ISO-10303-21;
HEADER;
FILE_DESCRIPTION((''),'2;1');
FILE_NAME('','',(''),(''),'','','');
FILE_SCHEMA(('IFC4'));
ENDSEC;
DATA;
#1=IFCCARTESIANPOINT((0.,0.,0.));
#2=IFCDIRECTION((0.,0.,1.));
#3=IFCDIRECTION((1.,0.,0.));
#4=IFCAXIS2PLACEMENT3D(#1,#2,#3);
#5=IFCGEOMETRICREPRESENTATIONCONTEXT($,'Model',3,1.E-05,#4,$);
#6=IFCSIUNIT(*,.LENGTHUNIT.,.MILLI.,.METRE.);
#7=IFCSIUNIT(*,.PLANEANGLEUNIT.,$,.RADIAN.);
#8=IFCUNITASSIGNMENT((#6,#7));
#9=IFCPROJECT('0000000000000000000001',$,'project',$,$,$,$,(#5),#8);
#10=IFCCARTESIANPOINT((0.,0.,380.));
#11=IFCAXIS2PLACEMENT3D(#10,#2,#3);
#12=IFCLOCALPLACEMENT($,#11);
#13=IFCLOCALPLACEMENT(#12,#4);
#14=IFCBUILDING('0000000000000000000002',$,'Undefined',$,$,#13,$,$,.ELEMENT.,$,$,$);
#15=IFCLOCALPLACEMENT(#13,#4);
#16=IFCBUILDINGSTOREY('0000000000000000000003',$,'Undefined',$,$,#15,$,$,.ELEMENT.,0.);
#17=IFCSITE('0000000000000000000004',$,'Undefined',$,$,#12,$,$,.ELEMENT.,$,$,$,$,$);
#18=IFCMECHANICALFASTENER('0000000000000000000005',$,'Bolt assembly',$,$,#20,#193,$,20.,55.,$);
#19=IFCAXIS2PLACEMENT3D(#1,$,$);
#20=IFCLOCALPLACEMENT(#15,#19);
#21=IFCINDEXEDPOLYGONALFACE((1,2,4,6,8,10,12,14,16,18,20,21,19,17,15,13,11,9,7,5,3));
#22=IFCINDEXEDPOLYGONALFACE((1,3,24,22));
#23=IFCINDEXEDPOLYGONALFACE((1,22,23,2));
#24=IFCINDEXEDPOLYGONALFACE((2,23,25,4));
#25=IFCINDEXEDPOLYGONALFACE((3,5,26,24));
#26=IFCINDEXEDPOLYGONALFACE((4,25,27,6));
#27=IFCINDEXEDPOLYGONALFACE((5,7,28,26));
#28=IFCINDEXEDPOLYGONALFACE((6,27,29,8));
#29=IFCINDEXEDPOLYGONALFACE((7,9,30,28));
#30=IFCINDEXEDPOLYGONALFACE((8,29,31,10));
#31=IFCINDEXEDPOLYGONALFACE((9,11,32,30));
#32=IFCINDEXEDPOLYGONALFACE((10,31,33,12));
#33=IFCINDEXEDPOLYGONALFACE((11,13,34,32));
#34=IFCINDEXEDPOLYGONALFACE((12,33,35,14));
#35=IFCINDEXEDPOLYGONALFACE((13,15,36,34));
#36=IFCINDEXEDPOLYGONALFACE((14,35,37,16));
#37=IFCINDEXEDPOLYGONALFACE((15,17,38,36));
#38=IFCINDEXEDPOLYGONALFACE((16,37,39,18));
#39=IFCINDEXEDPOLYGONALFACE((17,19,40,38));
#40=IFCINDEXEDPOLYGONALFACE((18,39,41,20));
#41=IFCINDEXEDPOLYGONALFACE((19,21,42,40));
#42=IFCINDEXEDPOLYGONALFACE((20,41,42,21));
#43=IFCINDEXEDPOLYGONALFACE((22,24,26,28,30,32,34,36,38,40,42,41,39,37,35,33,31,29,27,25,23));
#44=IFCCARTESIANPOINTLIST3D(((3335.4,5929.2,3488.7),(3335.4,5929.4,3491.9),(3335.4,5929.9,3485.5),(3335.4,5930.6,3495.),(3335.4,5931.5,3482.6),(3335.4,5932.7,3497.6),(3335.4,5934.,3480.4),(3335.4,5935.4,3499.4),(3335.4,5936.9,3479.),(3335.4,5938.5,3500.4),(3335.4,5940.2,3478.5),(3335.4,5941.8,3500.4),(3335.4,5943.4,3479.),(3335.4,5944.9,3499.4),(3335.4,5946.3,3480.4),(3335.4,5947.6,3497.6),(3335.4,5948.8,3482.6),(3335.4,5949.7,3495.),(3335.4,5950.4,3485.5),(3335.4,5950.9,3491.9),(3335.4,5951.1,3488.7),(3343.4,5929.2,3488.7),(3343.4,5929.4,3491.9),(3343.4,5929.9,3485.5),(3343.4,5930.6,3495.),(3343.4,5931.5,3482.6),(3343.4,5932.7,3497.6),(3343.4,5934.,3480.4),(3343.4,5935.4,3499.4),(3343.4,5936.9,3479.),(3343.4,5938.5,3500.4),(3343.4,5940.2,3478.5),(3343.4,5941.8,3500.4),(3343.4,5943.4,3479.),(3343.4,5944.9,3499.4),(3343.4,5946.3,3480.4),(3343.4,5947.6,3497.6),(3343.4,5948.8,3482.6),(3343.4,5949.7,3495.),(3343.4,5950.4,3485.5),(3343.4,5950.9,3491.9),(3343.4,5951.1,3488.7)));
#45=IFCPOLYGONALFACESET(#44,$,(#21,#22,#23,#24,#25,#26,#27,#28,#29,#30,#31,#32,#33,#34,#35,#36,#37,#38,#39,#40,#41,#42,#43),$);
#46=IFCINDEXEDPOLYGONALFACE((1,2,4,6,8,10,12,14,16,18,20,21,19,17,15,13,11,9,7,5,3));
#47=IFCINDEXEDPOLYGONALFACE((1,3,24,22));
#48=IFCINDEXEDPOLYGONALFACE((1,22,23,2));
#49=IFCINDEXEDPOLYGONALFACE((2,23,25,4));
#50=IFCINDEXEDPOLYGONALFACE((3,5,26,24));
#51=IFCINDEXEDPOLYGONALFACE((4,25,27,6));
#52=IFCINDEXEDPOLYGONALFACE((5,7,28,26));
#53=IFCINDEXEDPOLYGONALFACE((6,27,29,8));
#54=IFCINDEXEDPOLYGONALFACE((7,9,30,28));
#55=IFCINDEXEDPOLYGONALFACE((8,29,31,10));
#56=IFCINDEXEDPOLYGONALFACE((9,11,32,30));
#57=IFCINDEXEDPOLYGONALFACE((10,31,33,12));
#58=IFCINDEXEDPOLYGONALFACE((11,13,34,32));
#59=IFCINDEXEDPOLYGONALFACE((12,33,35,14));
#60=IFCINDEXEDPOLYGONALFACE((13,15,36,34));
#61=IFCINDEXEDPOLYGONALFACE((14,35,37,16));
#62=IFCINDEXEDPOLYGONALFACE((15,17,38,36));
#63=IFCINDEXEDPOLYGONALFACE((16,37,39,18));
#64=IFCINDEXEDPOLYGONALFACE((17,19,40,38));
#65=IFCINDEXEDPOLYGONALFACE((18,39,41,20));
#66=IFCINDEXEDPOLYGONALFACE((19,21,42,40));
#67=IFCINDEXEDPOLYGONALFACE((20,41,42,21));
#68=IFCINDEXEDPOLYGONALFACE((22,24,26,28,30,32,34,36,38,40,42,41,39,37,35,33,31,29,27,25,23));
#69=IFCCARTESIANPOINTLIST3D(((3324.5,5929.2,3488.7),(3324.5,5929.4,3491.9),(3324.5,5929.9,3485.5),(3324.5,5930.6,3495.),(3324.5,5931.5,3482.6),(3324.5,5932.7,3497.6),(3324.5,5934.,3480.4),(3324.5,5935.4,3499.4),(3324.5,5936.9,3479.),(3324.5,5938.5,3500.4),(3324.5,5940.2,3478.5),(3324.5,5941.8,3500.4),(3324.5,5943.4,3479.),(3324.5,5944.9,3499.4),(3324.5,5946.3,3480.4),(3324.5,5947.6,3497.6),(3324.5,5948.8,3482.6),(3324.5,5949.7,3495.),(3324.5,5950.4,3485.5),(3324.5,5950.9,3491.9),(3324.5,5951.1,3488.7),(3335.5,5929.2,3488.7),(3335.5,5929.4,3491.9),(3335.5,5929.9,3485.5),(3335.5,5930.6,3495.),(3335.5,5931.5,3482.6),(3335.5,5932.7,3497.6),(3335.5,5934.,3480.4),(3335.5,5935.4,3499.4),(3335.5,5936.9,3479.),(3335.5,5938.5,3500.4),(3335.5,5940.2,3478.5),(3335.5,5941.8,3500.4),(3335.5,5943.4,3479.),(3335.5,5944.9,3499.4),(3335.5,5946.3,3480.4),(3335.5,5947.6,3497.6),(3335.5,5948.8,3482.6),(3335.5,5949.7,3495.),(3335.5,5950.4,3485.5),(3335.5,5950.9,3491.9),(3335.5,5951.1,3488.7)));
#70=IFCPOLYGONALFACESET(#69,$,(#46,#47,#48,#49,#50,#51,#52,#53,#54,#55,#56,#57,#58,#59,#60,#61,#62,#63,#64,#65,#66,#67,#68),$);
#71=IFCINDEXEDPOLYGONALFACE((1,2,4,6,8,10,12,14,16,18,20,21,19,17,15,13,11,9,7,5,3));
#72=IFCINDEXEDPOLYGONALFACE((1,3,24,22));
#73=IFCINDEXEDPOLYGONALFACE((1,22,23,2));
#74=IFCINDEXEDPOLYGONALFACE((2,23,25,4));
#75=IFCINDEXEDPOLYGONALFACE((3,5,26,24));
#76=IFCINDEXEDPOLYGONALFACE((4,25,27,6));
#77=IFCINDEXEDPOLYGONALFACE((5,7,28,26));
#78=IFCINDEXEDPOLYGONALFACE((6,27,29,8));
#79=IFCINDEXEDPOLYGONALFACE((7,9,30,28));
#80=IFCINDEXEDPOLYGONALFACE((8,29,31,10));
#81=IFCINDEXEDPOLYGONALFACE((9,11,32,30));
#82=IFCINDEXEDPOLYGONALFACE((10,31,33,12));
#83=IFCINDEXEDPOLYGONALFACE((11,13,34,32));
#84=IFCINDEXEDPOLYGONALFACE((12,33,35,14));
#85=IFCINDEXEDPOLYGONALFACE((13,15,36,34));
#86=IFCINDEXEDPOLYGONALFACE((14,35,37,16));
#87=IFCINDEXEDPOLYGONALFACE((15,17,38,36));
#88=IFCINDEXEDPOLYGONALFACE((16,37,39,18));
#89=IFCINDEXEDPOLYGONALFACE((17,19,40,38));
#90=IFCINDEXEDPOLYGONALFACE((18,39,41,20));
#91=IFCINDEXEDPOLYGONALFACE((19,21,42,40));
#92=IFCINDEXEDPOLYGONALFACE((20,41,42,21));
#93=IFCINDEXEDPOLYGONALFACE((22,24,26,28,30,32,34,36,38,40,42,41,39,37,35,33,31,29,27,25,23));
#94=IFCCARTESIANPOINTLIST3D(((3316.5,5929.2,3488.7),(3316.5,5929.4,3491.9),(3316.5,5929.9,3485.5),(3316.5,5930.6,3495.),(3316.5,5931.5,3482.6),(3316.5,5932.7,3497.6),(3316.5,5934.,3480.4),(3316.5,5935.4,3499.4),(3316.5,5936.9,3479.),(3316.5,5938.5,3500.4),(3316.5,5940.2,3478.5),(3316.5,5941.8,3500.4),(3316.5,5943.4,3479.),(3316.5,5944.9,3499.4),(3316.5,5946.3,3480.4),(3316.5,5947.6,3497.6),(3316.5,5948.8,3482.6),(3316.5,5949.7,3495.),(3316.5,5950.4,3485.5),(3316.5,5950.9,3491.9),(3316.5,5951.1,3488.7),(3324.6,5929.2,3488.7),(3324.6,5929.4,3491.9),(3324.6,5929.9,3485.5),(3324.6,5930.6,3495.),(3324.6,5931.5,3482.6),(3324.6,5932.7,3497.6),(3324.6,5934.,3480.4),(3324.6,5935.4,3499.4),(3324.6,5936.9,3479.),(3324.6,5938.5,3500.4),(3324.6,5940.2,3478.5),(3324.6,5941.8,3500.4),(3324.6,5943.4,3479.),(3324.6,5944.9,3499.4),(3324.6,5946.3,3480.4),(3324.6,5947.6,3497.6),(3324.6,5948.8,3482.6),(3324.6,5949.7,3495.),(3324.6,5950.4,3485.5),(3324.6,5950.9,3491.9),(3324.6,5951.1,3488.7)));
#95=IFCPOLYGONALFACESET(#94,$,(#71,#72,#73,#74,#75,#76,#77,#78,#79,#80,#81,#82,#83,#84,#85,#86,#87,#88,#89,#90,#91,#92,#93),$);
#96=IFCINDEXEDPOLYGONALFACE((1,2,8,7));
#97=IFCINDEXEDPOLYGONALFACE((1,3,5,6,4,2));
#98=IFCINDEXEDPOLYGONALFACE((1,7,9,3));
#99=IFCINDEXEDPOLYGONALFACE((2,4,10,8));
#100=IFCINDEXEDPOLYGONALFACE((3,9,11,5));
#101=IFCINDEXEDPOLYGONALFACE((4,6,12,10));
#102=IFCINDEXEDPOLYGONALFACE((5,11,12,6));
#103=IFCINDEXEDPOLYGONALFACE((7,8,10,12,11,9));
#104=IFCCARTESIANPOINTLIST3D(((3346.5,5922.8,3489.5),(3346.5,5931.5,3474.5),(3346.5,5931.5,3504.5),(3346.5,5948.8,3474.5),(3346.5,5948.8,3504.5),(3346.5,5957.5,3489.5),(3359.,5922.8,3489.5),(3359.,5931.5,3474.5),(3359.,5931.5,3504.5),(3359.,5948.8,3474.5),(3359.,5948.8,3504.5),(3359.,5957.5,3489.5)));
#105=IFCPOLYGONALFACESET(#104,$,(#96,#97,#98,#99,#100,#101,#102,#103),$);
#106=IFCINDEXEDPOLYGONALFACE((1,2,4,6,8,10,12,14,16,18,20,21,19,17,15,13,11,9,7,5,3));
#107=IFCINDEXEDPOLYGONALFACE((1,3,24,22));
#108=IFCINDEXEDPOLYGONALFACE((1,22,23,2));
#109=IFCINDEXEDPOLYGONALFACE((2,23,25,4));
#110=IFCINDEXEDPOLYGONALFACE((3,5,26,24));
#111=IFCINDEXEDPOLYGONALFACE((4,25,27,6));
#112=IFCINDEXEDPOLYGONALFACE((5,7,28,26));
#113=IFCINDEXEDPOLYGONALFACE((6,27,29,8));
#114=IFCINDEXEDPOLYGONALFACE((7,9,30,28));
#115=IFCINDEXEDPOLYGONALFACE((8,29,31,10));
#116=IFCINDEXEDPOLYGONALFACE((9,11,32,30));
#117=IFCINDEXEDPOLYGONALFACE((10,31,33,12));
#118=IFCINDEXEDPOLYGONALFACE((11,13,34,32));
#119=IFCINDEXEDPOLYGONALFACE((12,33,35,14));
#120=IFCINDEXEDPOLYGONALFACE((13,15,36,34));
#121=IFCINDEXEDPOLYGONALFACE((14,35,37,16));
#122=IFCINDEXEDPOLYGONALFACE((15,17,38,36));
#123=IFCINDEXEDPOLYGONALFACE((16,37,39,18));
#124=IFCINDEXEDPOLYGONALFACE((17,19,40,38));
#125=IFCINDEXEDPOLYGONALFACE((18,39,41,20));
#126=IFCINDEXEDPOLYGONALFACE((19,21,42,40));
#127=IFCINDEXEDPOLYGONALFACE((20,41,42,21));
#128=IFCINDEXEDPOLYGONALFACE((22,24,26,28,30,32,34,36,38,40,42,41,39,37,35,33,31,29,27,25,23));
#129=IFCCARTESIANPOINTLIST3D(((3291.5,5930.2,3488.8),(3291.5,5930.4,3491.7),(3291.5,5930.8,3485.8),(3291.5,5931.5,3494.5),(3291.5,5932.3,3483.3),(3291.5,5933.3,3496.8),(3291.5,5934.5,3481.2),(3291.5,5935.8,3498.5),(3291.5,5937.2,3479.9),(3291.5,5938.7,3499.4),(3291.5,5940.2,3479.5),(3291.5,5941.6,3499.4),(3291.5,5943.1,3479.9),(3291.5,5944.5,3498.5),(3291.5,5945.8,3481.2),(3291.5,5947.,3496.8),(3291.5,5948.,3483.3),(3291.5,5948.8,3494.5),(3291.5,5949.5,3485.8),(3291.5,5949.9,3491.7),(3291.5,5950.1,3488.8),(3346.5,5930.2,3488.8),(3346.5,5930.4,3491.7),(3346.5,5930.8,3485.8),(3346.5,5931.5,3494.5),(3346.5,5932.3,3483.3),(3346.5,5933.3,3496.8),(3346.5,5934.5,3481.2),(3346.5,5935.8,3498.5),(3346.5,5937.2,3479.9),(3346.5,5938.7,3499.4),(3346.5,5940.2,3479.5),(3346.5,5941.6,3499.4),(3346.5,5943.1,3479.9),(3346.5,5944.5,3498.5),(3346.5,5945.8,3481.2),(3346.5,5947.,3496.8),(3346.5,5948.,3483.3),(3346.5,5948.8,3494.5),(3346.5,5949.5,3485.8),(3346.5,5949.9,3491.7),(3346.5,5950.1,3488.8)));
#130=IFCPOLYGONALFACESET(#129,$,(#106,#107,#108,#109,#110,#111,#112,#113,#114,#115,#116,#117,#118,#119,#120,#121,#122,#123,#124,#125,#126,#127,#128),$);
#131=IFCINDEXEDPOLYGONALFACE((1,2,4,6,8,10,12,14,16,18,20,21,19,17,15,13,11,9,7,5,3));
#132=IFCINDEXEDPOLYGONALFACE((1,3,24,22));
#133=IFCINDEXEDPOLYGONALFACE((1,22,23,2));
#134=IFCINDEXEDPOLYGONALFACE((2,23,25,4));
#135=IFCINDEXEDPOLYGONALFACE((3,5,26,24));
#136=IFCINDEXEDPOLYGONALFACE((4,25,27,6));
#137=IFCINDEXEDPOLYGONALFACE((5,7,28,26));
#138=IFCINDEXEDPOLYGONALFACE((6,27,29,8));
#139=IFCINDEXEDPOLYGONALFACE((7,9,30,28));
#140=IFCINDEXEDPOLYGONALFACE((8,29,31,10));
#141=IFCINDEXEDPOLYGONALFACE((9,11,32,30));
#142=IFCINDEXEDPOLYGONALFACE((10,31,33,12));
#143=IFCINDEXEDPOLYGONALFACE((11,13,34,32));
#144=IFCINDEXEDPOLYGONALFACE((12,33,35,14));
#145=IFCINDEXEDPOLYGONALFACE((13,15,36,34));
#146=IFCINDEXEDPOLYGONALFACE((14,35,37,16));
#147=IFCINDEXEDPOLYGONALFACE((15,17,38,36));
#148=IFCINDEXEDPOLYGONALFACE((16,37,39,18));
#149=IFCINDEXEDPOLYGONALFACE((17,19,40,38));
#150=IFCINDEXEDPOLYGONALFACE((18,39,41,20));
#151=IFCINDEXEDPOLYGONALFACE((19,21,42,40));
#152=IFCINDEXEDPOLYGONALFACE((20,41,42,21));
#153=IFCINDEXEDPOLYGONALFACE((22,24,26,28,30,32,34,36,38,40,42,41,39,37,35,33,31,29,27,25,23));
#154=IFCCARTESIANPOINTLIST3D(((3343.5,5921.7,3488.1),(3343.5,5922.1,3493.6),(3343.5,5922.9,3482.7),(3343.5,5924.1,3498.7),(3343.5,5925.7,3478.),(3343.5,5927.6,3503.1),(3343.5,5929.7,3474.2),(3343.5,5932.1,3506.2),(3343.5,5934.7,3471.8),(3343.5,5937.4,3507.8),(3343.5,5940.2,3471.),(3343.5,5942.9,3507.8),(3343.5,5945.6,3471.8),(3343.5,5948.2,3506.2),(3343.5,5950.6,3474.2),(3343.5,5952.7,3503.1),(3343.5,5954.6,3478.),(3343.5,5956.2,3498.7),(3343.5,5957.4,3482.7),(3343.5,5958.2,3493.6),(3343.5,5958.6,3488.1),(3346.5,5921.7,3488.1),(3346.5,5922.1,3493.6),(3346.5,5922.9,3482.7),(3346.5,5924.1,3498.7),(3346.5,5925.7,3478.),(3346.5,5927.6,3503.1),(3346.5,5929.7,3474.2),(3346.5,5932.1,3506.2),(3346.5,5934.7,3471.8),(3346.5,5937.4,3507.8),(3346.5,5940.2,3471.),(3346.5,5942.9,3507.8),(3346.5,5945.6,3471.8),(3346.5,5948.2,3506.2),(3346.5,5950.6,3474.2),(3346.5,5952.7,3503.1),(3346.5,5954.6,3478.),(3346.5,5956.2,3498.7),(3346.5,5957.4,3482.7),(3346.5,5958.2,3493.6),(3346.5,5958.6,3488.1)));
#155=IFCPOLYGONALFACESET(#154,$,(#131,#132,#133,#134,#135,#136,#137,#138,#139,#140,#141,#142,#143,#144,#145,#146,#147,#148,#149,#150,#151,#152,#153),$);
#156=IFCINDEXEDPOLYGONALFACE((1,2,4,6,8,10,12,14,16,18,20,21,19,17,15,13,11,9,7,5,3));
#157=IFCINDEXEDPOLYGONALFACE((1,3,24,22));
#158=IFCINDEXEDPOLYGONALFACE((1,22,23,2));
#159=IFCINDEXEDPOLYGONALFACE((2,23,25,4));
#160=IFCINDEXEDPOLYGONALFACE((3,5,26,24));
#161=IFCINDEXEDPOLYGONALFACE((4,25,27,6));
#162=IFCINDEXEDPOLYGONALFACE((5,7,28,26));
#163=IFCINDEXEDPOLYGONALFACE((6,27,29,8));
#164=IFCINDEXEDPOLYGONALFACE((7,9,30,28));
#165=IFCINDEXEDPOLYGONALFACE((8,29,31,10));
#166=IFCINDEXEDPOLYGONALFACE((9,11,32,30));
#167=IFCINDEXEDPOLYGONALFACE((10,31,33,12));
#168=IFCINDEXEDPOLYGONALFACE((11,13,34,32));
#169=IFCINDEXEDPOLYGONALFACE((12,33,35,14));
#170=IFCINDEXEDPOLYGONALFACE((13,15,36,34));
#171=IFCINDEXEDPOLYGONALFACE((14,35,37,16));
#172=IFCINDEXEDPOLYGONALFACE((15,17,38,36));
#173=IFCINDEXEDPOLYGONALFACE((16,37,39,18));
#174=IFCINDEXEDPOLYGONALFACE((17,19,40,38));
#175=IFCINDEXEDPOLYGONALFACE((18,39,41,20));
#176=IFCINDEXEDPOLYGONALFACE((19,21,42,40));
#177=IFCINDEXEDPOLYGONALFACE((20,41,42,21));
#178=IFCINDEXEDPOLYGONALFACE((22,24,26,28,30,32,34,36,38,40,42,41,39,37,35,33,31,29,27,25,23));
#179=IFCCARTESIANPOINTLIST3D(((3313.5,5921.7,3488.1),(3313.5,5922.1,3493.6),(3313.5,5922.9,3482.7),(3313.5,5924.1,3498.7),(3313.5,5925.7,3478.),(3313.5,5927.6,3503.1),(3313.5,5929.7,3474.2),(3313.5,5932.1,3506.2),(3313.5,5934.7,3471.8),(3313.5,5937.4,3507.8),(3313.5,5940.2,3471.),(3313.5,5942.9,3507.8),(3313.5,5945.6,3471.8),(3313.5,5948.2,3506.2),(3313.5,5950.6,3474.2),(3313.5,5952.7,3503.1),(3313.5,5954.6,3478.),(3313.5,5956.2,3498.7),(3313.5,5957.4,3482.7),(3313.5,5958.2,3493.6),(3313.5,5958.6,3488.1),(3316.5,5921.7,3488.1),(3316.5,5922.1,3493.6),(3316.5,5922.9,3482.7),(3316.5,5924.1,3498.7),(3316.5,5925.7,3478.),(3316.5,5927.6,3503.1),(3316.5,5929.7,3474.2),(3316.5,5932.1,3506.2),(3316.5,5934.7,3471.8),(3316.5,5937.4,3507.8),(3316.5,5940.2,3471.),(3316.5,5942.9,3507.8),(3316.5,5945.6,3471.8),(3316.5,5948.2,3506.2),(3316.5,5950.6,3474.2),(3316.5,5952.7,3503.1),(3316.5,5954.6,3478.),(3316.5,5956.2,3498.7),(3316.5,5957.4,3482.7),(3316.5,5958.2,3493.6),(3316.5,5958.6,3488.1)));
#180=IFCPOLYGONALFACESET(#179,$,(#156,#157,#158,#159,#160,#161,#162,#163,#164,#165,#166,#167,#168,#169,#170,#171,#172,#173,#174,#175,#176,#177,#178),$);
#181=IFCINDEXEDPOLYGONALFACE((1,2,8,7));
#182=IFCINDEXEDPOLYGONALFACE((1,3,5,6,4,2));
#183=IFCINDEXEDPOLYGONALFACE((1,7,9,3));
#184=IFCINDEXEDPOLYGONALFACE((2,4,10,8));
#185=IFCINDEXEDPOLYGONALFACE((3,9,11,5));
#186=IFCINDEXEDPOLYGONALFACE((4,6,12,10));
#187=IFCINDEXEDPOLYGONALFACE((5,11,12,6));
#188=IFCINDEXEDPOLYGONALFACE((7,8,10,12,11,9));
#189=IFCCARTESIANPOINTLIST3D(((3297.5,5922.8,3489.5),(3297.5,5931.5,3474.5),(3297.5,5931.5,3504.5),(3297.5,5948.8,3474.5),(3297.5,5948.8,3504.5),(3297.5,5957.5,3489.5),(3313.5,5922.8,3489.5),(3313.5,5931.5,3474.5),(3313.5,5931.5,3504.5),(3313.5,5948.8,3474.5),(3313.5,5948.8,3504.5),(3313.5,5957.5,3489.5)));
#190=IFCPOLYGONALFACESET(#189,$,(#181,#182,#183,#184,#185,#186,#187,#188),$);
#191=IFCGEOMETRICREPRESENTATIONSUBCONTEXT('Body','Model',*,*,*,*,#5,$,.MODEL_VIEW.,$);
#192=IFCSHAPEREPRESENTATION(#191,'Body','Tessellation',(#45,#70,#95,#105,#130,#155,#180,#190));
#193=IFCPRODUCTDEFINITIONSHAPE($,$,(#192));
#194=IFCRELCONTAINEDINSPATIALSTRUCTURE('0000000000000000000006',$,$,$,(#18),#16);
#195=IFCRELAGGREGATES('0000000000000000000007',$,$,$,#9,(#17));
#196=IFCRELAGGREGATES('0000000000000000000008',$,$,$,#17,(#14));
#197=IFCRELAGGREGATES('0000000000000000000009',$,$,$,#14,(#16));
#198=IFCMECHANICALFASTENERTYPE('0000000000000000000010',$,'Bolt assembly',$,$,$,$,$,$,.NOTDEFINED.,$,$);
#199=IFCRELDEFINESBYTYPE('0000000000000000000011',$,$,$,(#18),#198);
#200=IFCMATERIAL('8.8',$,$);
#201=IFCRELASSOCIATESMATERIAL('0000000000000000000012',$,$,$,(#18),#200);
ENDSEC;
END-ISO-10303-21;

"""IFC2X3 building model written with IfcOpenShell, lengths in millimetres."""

from ifc_helpers import new_model, si_unit, frame, origin_with_axes, origin_2d_with_axis, place, context, subcontext, project, spatial, polyline, circle, outline, extrude, source, transform, mapped, material, type_object, element, save


model = new_model("IFC2X3")

# Units and contexts
model_context = context("Model", 3, precision=1e-05, world=origin_with_axes())
body_context = subcontext(model_context, "Body", "Model", "MODEL_VIEW")
ifc_project = project(units=[si_unit("LENGTHUNIT", "METRE", prefix="MILLI"), si_unit("PLANEANGLEUNIT", "RADIAN")], contexts=[model_context])

# Site, building, storey
site_placement = place(None, frame((0.0, 0.0, 380.0), z_axis=(0.0, 0.0, 1.0), x_axis=(1.0, 0.0, 0.0)))
site = spatial("IfcSite", under=ifc_project, at=site_placement, Name="Undefined", CompositionType="ELEMENT")
building_placement = place(site_placement, origin_with_axes())
building = spatial("IfcBuilding", under=site, at=building_placement, Name="Undefined", CompositionType="ELEMENT")
storey_placement = place(building_placement, origin_with_axes())
storey = spatial("IfcBuildingStorey", under=building, at=storey_placement, Name="Undefined", CompositionType="ELEMENT", Elevation=0.0)

# Mechanical fastener
ifc_material_1 = material(Name="8.8")
mechanical_fastener_type = type_object("IfcMechanicalFastenerType", Name="Bolt assembly")
shared_shape_1 = source(origin_with_axes(), body_context, "Body", "SweptSolid", [
    extrude(circle(Radius=11.0, at=origin_2d_with_axis()), frame((0.0, -18.9, 0.0), z_axis=(0.0, 1.0, 0.0), x_axis=(1.0, 0.0, 0.0)), (0.0, 0.0, 1.0), 8.0),
    extrude(circle(Radius=11.0, at=origin_2d_with_axis()), frame((0.0, -11.0, 0.0), z_axis=(0.0, 1.0, 0.0), x_axis=(1.0, 0.0, 0.0)), (0.0, 0.0, 1.0), 11.0),
    extrude(circle(Radius=11.0, at=origin_2d_with_axis()), frame((0.0, -0.1, 0.0), z_axis=(0.0, 1.0, 0.0), x_axis=(1.0, 0.0, 0.0)), (0.0, 0.0, 1.0), 8.1),
    extrude(outline(polyline([(15.0, -8.7), (15.0, 8.7), (0.0, 17.3), (-15.0, 8.7), (-15.0, -8.7), (0.0, -17.3), (15.0, -8.7)])), frame((0.0, -34.5, 0.0), z_axis=(0.0, 1.0, 0.0), x_axis=(1.0, 0.0, 0.0)), (0.0, 0.0, 1.0), 12.5),
    extrude(circle(Radius=10.0, at=origin_2d_with_axis()), frame((0.0, -22.0, 0.0), z_axis=(0.0, 1.0, 0.0), x_axis=(1.0, 0.0, 0.0)), (0.0, 0.0, 1.0), 55.0),
    extrude(circle(Radius=18.5, at=origin_2d_with_axis()), frame((0.0, -22.0, 0.0), z_axis=(0.0, 1.0, 0.0), x_axis=(1.0, 0.0, 0.0)), (0.0, 0.0, 1.0), 3.0),
    extrude(circle(Radius=18.5, at=origin_2d_with_axis()), frame((0.0, 8.0, 0.0), z_axis=(0.0, 1.0, 0.0), x_axis=(1.0, 0.0, 0.0)), (0.0, 0.0, 1.0), 3.0),
    extrude(outline(polyline([(15.0, -8.7), (15.0, 8.7), (0.0, 17.3), (-15.0, 8.7), (-15.0, -8.7), (0.0, -17.3), (15.0, -8.7)])), frame((0.0, 11.0, 0.0), z_axis=(0.0, 1.0, 0.0), x_axis=(1.0, 0.0, 0.0)), (0.0, 0.0, 1.0), 16.0),
])
for number, where, z_axis, x_axis, name in (
    (1, (3324.5, 5902.7, 3579.5), (0.0, 1.0, 0.0), (0.0, 0.0, -1.0), "Bolt assembly"),
):
    element("IfcMechanicalFastener", number, at=place(storey_placement, frame(where, z_axis=z_axis, x_axis=x_axis)), inside=storey, type_object=mechanical_fastener_type, material=ifc_material_1, Name=name, NominalDiameter=20.0, NominalLength=55.0, context=body_context, shape_type="MappedRepresentation", body=[
        mapped(shared_shape_1, transform((90.0, 0.0, 37.5))),
    ])

save(model, "model.ifc")
